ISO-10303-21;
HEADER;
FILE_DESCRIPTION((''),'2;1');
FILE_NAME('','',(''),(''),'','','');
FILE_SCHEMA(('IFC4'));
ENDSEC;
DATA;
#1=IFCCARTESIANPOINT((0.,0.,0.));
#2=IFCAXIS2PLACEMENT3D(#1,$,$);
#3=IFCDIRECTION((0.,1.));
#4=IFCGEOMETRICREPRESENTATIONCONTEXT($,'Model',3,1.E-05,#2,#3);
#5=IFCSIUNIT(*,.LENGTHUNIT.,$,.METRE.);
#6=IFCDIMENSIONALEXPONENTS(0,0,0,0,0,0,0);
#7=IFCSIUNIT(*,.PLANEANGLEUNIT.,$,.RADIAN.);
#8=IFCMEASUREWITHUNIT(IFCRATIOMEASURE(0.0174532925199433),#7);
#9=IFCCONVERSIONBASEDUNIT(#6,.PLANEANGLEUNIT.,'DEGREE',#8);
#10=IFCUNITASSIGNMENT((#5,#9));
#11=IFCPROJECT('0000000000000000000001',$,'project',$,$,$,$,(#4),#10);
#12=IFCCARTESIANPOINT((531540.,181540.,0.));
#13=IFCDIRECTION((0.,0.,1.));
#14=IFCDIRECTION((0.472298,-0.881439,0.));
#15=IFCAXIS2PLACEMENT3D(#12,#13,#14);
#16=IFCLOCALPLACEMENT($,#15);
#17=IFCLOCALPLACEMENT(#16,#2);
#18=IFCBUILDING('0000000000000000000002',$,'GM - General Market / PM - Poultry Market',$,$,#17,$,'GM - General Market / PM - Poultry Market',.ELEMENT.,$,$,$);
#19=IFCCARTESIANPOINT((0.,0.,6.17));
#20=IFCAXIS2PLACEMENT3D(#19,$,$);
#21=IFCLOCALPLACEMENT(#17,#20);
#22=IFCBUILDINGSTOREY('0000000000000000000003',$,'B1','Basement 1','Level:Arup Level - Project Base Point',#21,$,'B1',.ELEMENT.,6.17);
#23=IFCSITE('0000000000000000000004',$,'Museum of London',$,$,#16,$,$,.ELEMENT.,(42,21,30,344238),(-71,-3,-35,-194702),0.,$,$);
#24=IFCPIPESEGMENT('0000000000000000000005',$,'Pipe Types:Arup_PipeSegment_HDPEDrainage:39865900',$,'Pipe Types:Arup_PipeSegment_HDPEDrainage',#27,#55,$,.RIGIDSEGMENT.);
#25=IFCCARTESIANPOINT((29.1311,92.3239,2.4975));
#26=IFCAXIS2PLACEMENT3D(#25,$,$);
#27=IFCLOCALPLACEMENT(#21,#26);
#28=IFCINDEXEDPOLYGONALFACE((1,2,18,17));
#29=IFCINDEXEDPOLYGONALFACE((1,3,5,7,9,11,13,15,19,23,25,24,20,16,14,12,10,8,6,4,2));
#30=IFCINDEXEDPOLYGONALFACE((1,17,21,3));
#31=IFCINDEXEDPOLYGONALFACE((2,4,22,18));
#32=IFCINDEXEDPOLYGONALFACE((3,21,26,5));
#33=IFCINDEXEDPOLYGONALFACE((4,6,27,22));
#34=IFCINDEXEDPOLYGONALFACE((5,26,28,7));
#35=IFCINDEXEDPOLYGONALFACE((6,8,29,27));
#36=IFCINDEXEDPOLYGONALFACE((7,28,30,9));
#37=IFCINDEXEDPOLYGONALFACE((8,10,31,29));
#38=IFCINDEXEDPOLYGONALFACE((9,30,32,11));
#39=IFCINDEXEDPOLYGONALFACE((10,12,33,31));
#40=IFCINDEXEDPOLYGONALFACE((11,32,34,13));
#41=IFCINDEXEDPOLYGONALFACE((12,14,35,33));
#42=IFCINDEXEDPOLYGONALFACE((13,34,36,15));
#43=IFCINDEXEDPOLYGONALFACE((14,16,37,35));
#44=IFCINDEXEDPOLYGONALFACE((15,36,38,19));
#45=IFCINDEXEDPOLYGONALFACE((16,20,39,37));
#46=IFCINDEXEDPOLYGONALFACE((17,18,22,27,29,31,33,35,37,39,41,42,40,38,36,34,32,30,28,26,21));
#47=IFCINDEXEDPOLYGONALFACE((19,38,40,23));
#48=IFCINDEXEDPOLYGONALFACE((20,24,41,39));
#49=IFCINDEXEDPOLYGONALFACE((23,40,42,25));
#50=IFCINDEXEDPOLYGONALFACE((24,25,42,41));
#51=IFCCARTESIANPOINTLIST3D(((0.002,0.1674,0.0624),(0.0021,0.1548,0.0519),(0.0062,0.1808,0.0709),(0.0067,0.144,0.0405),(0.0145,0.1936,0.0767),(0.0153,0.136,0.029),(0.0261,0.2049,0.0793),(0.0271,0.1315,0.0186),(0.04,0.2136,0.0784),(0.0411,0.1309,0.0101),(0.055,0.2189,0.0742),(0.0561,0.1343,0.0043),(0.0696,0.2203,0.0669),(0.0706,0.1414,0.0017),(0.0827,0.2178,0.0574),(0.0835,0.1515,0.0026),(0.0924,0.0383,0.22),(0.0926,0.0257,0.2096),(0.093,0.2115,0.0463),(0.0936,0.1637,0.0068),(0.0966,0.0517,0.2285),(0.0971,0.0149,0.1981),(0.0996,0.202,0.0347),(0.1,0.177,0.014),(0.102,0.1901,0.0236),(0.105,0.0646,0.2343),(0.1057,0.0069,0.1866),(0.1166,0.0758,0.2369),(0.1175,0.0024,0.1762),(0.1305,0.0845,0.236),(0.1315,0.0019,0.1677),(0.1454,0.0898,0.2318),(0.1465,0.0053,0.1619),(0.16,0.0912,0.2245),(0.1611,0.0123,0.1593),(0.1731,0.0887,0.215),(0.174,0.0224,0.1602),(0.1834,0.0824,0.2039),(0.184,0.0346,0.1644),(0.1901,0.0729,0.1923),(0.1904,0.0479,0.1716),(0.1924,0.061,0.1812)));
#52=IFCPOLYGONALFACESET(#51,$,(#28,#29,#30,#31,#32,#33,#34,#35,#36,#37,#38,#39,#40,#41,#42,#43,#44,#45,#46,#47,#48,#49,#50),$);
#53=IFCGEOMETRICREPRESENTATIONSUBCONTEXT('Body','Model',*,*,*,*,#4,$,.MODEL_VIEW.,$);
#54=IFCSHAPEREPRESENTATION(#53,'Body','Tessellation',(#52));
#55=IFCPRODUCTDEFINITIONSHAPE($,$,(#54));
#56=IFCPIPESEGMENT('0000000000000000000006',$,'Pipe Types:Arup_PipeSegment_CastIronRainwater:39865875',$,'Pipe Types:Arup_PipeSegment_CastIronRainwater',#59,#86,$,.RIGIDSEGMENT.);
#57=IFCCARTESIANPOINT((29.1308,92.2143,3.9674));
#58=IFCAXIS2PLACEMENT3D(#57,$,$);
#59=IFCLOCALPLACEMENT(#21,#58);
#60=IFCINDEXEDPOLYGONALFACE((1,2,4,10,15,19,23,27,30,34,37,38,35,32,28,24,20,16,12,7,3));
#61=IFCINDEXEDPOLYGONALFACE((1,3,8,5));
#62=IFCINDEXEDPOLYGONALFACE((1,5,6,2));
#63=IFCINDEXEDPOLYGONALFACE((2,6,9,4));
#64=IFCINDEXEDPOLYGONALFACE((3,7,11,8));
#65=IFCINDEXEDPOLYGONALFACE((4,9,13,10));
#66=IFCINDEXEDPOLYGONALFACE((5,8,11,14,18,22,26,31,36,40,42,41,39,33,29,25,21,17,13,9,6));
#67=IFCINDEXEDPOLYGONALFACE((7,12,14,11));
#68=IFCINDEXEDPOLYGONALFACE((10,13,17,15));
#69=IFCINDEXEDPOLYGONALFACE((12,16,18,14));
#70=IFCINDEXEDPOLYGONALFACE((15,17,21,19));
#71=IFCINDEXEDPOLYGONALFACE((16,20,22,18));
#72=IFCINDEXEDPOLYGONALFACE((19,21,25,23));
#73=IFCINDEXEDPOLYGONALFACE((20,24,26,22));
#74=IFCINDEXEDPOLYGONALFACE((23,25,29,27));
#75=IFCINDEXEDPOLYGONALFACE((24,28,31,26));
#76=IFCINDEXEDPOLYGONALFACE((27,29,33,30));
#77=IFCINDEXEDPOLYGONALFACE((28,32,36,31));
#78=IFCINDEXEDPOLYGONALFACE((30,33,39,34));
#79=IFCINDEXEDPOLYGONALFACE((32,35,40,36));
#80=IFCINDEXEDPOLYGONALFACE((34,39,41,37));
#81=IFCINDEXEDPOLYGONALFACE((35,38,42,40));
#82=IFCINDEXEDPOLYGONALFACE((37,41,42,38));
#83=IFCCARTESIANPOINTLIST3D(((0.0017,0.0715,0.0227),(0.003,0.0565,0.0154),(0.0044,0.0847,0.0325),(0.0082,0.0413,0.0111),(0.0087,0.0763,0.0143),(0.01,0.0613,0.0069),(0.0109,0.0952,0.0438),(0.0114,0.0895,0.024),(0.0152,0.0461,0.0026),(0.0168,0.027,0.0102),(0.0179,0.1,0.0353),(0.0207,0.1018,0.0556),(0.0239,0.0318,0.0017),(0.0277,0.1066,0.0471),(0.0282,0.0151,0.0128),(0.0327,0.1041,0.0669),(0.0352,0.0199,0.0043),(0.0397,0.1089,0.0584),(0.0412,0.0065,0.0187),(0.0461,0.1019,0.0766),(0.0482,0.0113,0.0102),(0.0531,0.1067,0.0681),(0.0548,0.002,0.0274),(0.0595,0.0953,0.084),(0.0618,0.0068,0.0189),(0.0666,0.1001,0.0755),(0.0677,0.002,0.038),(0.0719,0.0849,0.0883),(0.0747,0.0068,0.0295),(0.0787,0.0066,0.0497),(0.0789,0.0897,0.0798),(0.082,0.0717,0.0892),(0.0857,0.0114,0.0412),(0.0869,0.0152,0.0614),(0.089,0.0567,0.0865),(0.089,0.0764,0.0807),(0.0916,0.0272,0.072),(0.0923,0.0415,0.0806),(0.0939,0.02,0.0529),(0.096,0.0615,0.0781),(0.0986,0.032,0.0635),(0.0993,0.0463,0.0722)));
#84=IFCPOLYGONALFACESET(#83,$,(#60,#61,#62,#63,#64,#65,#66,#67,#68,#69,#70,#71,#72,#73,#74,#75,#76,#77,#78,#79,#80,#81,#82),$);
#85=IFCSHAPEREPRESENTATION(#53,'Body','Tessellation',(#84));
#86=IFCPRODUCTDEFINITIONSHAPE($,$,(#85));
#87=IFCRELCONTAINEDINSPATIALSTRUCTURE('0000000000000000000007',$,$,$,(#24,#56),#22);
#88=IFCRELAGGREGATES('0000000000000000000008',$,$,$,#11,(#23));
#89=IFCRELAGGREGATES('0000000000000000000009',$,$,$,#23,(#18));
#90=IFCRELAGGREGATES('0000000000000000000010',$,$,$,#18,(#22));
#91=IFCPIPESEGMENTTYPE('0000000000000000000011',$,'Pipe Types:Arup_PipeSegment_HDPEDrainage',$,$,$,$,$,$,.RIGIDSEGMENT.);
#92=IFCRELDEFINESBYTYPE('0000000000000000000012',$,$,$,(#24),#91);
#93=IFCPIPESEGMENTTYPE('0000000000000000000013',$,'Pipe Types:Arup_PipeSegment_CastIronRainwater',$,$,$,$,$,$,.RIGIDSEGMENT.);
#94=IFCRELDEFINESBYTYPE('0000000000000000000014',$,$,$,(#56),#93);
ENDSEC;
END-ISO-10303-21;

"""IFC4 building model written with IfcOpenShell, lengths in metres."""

from ifc_helpers import new_model, entity, si_unit, converted_unit, direction, frame, origin, origin_2d_with_axis, place, context, subcontext, project, spatial, circle, extrude, type_object, element, save


model = new_model("IFC4")

# Units and contexts
model_context = context("Model", 3, precision=1e-05, world=origin(), true_north=direction((0.0, 1.0)))
body_context = subcontext(model_context, "Body", "Model", "MODEL_VIEW")
ifc_project = project(units=[si_unit("LENGTHUNIT", "METRE"), converted_unit("PLANEANGLEUNIT", "DEGREE", entity("IfcRatioMeasure", 0.0174532925199433), si_unit("PLANEANGLEUNIT", "RADIAN"), dimensions=[0, 0, 0, 0, 0, 0, 0])], contexts=[model_context])

# Site, building, storey
site_placement = place(None, frame((531540.0, 181540.0, 0.0), z_axis=(0.0, 0.0, 1.0), x_axis=(0.472298, -0.881439, 0.0)))
site = spatial("IfcSite", under=ifc_project, at=site_placement, Name="Museum of London", CompositionType="ELEMENT", RefLatitude=(42, 21, 30, 344238), RefLongitude=(-71, -3, -35, -194702), RefElevation=0.0)
building_placement = place(site_placement, origin())
building = spatial("IfcBuilding", under=site, at=building_placement, Name="GM - General Market / PM - Poultry Market", LongName="GM - General Market / PM - Poultry Market", CompositionType="ELEMENT")
storey_placement = place(building_placement, frame((0.0, 0.0, 6.17)))
storey = spatial("IfcBuildingStorey", under=building, at=storey_placement, Name="B1", Description="Basement 1", ObjectType="Level:Arup Level - Project Base Point", LongName="B1", CompositionType="ELEMENT", Elevation=6.17)

# Pipe segment
pipe_segment_type_1 = type_object("IfcPipeSegmentType", Name="Pipe Types:Arup_PipeSegment_HDPEDrainage", PredefinedType="RIGIDSEGMENT")
pipe_segment_1_placement = place(storey_placement, frame((29.1311, 92.3239, 2.4975)))
element("IfcPipeSegment", 1, at=pipe_segment_1_placement, inside=storey, type_object=pipe_segment_type_1, Name="Pipe Types:Arup_PipeSegment_HDPEDrainage:39865900", ObjectType="Pipe Types:Arup_PipeSegment_HDPEDrainage", PredefinedType="RIGIDSEGMENT", context=body_context, shape_type="SweptSolid", body=[
    extrude(circle(Radius=0.055, at=origin_2d_with_axis()), frame((0.0518, 0.1755, 0.0405), z_axis=(0.405659, -0.579172, 0.707107), x_axis=(-0.819074, -0.573689, 0.0)), (0.0, 0.0, 1.0), 0.2229),
])

# Pipe segment
pipe_segment_type_2 = type_object("IfcPipeSegmentType", Name="Pipe Types:Arup_PipeSegment_CastIronRainwater", PredefinedType="RIGIDSEGMENT")
pipe_segment_2_placement = place(storey_placement, frame((29.1308, 92.2143, 3.9674)))
element("IfcPipeSegment", 2, at=pipe_segment_2_placement, inside=storey, type_object=pipe_segment_type_2, Name="Pipe Types:Arup_PipeSegment_CastIronRainwater:39865875", ObjectType="Pipe Types:Arup_PipeSegment_CastIronRainwater", PredefinedType="RIGIDSEGMENT", context=body_context, shape_type="SweptSolid", body=[
    extrude(circle(Radius=0.056, at=origin_2d_with_axis()), frame((0.0471, 0.0528, 0.0497), z_axis=(0.583479, 0.39944, -0.707107), x_axis=(0.564893, -0.825164, 0.0)), (0.0, 0.0, 1.0), 0.012),
])

save(model, "model.ifc")
